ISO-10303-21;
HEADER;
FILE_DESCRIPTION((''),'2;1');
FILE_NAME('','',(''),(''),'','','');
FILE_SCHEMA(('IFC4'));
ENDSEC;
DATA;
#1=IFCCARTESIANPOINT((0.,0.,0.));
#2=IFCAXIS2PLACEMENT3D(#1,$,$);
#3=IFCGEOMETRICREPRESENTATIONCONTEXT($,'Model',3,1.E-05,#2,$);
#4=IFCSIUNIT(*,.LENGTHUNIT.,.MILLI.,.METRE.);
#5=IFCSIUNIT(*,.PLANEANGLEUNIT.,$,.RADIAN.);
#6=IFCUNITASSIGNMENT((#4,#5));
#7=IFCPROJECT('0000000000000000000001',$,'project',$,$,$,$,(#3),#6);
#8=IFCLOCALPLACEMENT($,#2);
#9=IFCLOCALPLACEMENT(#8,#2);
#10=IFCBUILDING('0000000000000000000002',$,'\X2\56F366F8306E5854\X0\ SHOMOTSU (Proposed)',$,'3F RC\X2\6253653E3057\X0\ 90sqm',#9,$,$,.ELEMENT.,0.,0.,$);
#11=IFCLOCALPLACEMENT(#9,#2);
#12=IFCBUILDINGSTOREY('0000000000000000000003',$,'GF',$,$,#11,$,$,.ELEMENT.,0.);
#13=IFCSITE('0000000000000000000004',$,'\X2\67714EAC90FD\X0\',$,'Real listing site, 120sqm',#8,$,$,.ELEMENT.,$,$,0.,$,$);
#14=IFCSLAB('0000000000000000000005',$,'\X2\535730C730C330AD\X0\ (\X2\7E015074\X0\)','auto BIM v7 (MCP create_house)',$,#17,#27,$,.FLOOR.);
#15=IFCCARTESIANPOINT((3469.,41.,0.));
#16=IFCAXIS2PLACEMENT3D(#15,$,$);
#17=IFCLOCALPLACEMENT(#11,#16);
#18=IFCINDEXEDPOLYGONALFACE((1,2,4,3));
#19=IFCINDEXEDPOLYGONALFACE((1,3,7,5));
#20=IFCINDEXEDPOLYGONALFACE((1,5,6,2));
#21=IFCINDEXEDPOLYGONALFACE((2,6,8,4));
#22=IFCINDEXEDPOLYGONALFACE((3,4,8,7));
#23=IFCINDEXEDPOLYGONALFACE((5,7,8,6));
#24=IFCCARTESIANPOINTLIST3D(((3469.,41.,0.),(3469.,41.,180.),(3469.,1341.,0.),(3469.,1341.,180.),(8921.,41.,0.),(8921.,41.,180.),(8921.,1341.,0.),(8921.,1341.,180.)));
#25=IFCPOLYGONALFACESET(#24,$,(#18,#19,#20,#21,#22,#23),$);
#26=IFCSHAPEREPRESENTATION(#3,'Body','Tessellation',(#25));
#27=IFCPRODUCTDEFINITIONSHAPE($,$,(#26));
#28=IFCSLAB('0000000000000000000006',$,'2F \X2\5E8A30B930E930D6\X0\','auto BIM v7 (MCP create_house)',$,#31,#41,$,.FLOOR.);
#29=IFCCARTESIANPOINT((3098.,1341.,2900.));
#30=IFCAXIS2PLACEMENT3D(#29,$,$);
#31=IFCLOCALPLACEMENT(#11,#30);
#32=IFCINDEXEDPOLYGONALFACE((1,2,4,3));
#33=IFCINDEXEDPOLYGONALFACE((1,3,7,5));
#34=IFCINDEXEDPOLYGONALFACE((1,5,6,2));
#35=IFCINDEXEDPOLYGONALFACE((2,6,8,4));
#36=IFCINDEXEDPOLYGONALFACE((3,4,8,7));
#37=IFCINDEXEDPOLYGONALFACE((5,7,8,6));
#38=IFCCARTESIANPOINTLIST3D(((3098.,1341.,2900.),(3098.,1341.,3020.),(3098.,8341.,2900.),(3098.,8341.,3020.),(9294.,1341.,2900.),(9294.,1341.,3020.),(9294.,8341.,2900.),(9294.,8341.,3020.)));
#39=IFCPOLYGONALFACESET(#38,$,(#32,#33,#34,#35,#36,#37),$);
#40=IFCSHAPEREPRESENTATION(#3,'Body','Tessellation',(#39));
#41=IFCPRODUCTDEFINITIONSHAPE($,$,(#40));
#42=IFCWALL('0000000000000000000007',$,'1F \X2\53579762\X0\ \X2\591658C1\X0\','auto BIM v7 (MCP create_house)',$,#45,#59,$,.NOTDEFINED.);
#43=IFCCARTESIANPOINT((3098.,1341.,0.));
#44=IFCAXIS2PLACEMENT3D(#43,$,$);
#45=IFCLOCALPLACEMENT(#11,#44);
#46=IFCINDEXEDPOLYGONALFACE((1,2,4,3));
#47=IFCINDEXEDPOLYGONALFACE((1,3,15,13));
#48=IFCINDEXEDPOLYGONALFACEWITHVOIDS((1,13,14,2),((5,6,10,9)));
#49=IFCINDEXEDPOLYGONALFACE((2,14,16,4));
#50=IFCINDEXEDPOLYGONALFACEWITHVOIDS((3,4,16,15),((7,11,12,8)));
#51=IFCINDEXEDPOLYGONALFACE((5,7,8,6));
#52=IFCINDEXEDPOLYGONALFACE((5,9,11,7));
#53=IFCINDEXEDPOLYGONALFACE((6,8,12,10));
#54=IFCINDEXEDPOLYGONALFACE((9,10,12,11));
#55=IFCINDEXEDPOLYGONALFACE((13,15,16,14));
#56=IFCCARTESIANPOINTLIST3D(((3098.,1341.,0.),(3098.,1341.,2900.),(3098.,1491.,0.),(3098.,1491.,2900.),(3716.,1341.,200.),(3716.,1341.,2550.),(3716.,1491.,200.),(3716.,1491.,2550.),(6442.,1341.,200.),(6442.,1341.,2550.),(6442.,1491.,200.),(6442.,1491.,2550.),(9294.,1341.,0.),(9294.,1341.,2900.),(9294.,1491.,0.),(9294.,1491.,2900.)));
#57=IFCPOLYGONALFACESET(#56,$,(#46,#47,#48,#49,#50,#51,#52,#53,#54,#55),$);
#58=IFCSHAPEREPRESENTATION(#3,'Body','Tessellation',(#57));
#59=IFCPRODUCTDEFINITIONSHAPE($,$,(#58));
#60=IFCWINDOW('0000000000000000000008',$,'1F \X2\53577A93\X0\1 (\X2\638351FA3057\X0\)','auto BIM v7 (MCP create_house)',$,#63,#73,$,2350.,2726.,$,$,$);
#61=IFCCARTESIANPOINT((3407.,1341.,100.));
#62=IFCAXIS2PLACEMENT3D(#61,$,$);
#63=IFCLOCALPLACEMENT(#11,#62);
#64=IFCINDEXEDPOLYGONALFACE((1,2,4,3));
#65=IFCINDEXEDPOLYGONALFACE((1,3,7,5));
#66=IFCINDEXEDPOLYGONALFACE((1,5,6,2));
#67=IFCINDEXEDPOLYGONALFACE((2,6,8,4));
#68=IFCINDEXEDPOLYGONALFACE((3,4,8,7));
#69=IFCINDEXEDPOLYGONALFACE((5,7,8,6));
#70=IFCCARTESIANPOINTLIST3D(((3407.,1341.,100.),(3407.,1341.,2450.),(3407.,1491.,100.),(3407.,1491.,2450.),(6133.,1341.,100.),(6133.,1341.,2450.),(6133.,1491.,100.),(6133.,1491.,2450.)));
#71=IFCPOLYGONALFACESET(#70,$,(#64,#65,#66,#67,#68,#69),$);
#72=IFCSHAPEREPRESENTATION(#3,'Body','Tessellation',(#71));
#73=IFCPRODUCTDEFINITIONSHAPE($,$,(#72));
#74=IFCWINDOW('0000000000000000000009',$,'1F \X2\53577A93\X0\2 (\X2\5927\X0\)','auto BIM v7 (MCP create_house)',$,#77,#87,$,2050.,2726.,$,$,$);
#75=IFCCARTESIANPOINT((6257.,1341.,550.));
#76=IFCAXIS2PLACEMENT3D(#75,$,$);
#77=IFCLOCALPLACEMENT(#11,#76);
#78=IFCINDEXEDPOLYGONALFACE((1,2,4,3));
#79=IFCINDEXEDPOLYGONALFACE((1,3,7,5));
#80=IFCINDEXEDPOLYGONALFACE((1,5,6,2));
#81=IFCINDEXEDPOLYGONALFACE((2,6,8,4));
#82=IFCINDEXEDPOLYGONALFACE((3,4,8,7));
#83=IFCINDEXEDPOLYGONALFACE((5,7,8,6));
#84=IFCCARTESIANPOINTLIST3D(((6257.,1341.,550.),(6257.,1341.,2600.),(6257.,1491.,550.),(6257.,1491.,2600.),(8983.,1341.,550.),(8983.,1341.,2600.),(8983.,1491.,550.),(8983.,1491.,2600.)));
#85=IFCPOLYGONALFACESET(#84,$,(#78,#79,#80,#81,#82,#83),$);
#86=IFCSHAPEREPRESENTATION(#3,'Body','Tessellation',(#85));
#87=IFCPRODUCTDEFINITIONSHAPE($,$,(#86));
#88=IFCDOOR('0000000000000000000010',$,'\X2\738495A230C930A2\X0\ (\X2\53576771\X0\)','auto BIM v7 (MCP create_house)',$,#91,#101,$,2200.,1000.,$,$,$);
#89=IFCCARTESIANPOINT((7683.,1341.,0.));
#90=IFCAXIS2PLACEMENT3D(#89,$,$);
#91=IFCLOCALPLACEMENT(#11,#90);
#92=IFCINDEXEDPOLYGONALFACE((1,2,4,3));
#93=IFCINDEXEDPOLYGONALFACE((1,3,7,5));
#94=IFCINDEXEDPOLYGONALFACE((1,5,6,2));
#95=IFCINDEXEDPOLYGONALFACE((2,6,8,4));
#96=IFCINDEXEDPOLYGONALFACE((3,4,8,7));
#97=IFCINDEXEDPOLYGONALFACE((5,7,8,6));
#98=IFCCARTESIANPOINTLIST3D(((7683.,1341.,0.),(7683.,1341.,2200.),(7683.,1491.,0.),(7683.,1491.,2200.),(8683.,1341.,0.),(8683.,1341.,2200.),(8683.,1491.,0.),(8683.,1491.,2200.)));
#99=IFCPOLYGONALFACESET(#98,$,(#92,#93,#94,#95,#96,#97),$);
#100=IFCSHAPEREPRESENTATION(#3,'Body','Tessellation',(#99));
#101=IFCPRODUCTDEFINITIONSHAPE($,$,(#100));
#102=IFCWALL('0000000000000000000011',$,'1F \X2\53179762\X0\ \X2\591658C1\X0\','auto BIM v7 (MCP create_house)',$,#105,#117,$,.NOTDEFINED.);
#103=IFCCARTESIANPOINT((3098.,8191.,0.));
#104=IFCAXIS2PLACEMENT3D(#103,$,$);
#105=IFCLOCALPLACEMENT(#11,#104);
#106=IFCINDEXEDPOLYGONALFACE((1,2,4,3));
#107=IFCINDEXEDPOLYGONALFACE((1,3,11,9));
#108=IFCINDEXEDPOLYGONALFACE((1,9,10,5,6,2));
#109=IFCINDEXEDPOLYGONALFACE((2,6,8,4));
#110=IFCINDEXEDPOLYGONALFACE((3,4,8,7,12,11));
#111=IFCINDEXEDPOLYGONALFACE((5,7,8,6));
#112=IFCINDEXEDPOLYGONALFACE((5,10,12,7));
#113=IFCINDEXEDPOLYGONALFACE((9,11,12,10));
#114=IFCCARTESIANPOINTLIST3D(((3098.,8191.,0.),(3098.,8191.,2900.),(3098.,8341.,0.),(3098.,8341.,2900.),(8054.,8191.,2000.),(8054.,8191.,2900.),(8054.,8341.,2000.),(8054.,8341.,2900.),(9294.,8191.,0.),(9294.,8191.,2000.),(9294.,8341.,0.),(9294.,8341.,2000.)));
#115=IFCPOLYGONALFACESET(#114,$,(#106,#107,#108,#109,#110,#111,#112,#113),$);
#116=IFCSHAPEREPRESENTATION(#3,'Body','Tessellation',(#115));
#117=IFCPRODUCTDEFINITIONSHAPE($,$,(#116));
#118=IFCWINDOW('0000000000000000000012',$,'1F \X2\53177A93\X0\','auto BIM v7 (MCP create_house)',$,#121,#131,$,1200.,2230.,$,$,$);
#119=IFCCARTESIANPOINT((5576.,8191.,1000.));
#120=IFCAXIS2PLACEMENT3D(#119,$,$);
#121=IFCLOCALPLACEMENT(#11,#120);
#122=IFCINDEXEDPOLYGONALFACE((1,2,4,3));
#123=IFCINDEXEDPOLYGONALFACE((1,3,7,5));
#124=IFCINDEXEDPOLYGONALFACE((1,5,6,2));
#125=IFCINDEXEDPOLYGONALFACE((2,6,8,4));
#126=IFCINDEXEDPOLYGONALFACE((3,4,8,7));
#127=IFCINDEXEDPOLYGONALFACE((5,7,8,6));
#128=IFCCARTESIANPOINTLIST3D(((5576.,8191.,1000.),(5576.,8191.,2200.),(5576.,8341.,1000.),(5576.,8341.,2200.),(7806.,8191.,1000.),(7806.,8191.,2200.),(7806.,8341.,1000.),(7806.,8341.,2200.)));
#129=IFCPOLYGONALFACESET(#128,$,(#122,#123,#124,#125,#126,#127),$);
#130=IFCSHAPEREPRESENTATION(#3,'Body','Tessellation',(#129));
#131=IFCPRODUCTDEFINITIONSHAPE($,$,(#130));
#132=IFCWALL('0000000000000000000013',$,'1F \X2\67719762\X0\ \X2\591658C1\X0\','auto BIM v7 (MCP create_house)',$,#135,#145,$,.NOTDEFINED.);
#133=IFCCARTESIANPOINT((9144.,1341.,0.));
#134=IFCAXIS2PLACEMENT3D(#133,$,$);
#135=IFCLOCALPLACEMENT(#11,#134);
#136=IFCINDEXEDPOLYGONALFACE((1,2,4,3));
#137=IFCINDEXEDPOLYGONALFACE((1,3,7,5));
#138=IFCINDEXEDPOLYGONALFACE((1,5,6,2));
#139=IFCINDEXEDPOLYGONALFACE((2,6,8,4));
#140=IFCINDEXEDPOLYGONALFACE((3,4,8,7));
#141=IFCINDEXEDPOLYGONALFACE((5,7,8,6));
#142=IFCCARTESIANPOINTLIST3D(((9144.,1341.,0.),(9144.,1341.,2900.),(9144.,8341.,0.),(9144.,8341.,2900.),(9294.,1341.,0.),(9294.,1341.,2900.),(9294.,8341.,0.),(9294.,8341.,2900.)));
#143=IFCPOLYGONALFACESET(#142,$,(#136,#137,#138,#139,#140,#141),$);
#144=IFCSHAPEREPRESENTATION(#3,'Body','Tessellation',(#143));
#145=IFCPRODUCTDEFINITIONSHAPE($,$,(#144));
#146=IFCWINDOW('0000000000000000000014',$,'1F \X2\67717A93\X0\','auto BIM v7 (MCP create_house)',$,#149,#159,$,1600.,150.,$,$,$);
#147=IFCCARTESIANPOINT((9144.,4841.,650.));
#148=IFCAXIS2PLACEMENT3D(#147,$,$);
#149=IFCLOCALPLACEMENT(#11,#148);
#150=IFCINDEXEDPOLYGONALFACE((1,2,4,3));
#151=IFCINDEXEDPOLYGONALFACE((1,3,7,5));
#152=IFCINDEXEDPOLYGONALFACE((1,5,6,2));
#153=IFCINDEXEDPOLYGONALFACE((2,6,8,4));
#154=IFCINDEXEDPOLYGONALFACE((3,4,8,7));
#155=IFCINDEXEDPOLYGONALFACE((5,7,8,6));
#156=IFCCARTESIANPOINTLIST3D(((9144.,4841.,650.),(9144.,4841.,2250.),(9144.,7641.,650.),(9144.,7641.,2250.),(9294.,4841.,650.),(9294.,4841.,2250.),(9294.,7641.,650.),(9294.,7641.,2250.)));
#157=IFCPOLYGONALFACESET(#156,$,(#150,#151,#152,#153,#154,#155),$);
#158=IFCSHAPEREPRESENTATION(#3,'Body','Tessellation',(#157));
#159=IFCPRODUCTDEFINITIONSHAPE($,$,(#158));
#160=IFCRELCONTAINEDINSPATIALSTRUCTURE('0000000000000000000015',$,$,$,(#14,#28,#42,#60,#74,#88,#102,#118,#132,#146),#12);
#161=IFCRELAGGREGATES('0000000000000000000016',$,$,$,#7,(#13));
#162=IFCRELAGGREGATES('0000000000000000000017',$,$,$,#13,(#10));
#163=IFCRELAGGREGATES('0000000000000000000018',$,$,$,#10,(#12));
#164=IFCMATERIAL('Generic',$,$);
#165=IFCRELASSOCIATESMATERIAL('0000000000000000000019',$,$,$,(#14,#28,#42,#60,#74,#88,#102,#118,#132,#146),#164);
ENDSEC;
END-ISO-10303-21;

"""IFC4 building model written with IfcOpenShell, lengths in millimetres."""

from ifc_helpers import new_model, si_unit, frame, frame_2d, origin, place, context, project, spatial, rectangle, extrude, material, element, fill, save


model = new_model("IFC4")

# Units and contexts
model_context = context("Model", 3, precision=1e-05, world=origin())
ifc_project = project(units=[si_unit("LENGTHUNIT", "METRE", prefix="MILLI"), si_unit("PLANEANGLEUNIT", "RADIAN")], contexts=[model_context])

# Site, building, storey
site_placement = place(None, origin())
site = spatial("IfcSite", under=ifc_project, at=site_placement, Name="東京都", ObjectType="Real listing site, 120sqm", CompositionType="ELEMENT", RefElevation=0.0)
building_placement = place(site_placement, origin())
building = spatial("IfcBuilding", under=site, at=building_placement, Name="図書の塔 SHOMOTSU (Proposed)", ObjectType="3F RC打放し 90sqm", CompositionType="ELEMENT", ElevationOfRefHeight=0.0, ElevationOfTerrain=0.0)
storey_placement = place(building_placement, origin())
storey = spatial("IfcBuildingStorey", under=building, at=storey_placement, Name="GF", CompositionType="ELEMENT", Elevation=0.0)

# Slabs
ifc_material = material(Name="Generic")
slab_1_placement = place(storey_placement, frame((3469.0, 41.0, 0.0)))
element("IfcSlab", 1, at=slab_1_placement, inside=storey, material=ifc_material, Name="南デッキ (縁側)", Description="auto BIM v7 (MCP create_house)", PredefinedType="FLOOR", context=model_context, shape_type="SweptSolid", body=[
    extrude(rectangle(XDim=5452.0, YDim=1300.0, at=frame_2d((2726.0, 650.0))), frame((3469.0, 41.0, 0.0)), (0.0, 0.0, 1.0), 180.0),
])
slab_2_placement = place(storey_placement, frame((3098.0, 1341.0, 2900.0)))
element("IfcSlab", 2, at=slab_2_placement, inside=storey, material=ifc_material, Name="2F 床スラブ", Description="auto BIM v7 (MCP create_house)", PredefinedType="FLOOR", context=model_context, shape_type="SweptSolid", body=[
    extrude(rectangle(XDim=6196.0, YDim=7000.0, at=frame_2d((3098.0, 3500.0))), frame((3098.0, 1341.0, 2900.0)), (0.0, 0.0, 1.0), 120.0),
])

# Wall, openings, windows, door
wall_1_placement = place(storey_placement, frame((3098.0, 1341.0, 0.0)))
wall_1 = element("IfcWall", 3, at=wall_1_placement, inside=storey, material=ifc_material, Name="1F 南面 外壁", Description="auto BIM v7 (MCP create_house)", PredefinedType="NOTDEFINED", context=model_context, shape_type="SweptSolid", body=[
    extrude(rectangle(XDim=6196.0, YDim=150.0, at=frame_2d((3098.0, 75.0))), frame((3098.0, 1341.0, 0.0)), (0.0, 0.0, 1.0), 2900.0),
])
opening_1_placement = place(storey_placement, frame((3407.0, 1341.0, 100.0)))
opening_1 = element("IfcOpeningElement", 4, at=opening_1_placement, cuts=wall_1, PredefinedType="NOTDEFINED", context=model_context, shape_type="SweptSolid", body=[
    extrude(rectangle(XDim=2726.0, YDim=150.0, at=frame_2d((1363.0, 75.0))), frame((3407.0, 1341.0, 100.0)), (0.0, 0.0, 1.0), 2350.0),
])
opening_2_placement = place(storey_placement, frame((6257.0, 1341.0, 550.0)))
opening_2 = element("IfcOpeningElement", 5, at=opening_2_placement, cuts=wall_1, PredefinedType="NOTDEFINED", context=model_context, shape_type="SweptSolid", body=[
    extrude(rectangle(XDim=2726.0, YDim=150.0, at=frame_2d((1363.0, 75.0))), frame((6257.0, 1341.0, 550.0)), (0.0, 0.0, 1.0), 2050.0),
])
opening_3_placement = place(storey_placement, frame((7683.0, 1341.0, 0.0)))
opening_3 = element("IfcOpeningElement", 6, at=opening_3_placement, cuts=wall_1, PredefinedType="NOTDEFINED", context=model_context, shape_type="SweptSolid", body=[
    extrude(rectangle(XDim=1000.0, YDim=150.0, at=frame_2d((500.0, 75.0))), frame((7683.0, 1341.0, 0.0)), (0.0, 0.0, 1.0), 2200.0),
])
window_1_placement = place(storey_placement, frame((3407.0, 1341.0, 100.0)))
window_1 = element("IfcWindow", 7, at=window_1_placement, inside=storey, material=ifc_material, Name="1F 南窓1 (掃出し)", Description="auto BIM v7 (MCP create_house)", OverallHeight=2350.0, OverallWidth=2726.0, context=model_context, shape_type="SweptSolid", body=[
    extrude(rectangle(XDim=2726.0, YDim=150.0, at=frame_2d((1363.0, 75.0))), frame((3407.0, 1341.0, 100.0)), (0.0, 0.0, 1.0), 2350.0),
])
fill(opening_1, window_1)
window_2_placement = place(storey_placement, frame((6257.0, 1341.0, 550.0)))
window_2 = element("IfcWindow", 8, at=window_2_placement, inside=storey, material=ifc_material, Name="1F 南窓2 (大)", Description="auto BIM v7 (MCP create_house)", OverallHeight=2050.0, OverallWidth=2726.0, context=model_context, shape_type="SweptSolid", body=[
    extrude(rectangle(XDim=2726.0, YDim=150.0, at=frame_2d((1363.0, 75.0))), frame((6257.0, 1341.0, 550.0)), (0.0, 0.0, 1.0), 2050.0),
])
fill(opening_2, window_2)
door_placement = place(storey_placement, frame((7683.0, 1341.0, 0.0)))
door = element("IfcDoor", 9, at=door_placement, inside=storey, material=ifc_material, Name="玄関ドア (南東)", Description="auto BIM v7 (MCP create_house)", OverallHeight=2200.0, OverallWidth=1000.0, context=model_context, shape_type="SweptSolid", body=[
    extrude(rectangle(XDim=1000.0, YDim=150.0, at=frame_2d((500.0, 75.0))), frame((7683.0, 1341.0, 0.0)), (0.0, 0.0, 1.0), 2200.0),
])
fill(opening_3, door)

# Walls, openings, windows
wall_2_placement = place(storey_placement, frame((3098.0, 8191.0, 0.0)))
wall_2 = element("IfcWall", 10, at=wall_2_placement, inside=storey, material=ifc_material, Name="1F 北面 外壁", Description="auto BIM v7 (MCP create_house)", PredefinedType="NOTDEFINED", context=model_context, shape_type="SweptSolid", body=[
    extrude(rectangle(XDim=6196.0, YDim=150.0, at=frame_2d((3098.0, 75.0))), frame((3098.0, 8191.0, 0.0)), (0.0, 0.0, 1.0), 2900.0),
])
opening_4_placement = place(storey_placement, frame((5576.0, 8191.0, 1000.0)))
opening_4 = element("IfcOpeningElement", 11, at=opening_4_placement, cuts=wall_2, PredefinedType="NOTDEFINED", context=model_context, shape_type="SweptSolid", body=[
    extrude(rectangle(XDim=2230.0, YDim=150.0, at=frame_2d((1115.0, 75.0))), frame((5576.0, 8191.0, 1000.0)), (0.0, 0.0, 1.0), 1200.0),
])
window_3_placement = place(storey_placement, frame((5576.0, 8191.0, 1000.0)))
window_3 = element("IfcWindow", 12, at=window_3_placement, inside=storey, material=ifc_material, Name="1F 北窓", Description="auto BIM v7 (MCP create_house)", OverallHeight=1200.0, OverallWidth=2230.0, context=model_context, shape_type="SweptSolid", body=[
    extrude(rectangle(XDim=2230.0, YDim=150.0, at=frame_2d((1115.0, 75.0))), frame((5576.0, 8191.0, 1000.0)), (0.0, 0.0, 1.0), 1200.0),
])
fill(opening_4, window_3)
wall_3_placement = place(storey_placement, frame((9144.0, 1341.0, 0.0)))
wall_3 = element("IfcWall", 13, at=wall_3_placement, inside=storey, material=ifc_material, Name="1F 東面 外壁", Description="auto BIM v7 (MCP create_house)", PredefinedType="NOTDEFINED", context=model_context, shape_type="SweptSolid", body=[
    extrude(rectangle(XDim=150.0, YDim=7000.0, at=frame_2d((75.0, 3500.0))), frame((9144.0, 1341.0, 0.0)), (0.0, 0.0, 1.0), 2900.0),
])
opening_5_placement = place(storey_placement, frame((9144.0, 4841.0, 650.0)))
opening_5 = element("IfcOpeningElement", 14, at=opening_5_placement, cuts=wall_3, PredefinedType="NOTDEFINED", context=model_context, shape_type="SweptSolid", body=[
    extrude(rectangle(XDim=150.0, YDim=2800.0, at=frame_2d((75.0, 1400.0))), frame((9144.0, 4841.0, 650.0)), (0.0, 0.0, 1.0), 1600.0),
])
window_4_placement = place(storey_placement, frame((9144.0, 4841.0, 650.0)))
window_4 = element("IfcWindow", 15, at=window_4_placement, inside=storey, material=ifc_material, Name="1F 東窓", Description="auto BIM v7 (MCP create_house)", OverallHeight=1600.0, OverallWidth=150.0, context=model_context, shape_type="SweptSolid", body=[
    extrude(rectangle(XDim=150.0, YDim=2800.0, at=frame_2d((75.0, 1400.0))), frame((9144.0, 4841.0, 650.0)), (0.0, 0.0, 1.0), 1600.0),
])
fill(opening_5, window_4)

save(model, "model.ifc")
